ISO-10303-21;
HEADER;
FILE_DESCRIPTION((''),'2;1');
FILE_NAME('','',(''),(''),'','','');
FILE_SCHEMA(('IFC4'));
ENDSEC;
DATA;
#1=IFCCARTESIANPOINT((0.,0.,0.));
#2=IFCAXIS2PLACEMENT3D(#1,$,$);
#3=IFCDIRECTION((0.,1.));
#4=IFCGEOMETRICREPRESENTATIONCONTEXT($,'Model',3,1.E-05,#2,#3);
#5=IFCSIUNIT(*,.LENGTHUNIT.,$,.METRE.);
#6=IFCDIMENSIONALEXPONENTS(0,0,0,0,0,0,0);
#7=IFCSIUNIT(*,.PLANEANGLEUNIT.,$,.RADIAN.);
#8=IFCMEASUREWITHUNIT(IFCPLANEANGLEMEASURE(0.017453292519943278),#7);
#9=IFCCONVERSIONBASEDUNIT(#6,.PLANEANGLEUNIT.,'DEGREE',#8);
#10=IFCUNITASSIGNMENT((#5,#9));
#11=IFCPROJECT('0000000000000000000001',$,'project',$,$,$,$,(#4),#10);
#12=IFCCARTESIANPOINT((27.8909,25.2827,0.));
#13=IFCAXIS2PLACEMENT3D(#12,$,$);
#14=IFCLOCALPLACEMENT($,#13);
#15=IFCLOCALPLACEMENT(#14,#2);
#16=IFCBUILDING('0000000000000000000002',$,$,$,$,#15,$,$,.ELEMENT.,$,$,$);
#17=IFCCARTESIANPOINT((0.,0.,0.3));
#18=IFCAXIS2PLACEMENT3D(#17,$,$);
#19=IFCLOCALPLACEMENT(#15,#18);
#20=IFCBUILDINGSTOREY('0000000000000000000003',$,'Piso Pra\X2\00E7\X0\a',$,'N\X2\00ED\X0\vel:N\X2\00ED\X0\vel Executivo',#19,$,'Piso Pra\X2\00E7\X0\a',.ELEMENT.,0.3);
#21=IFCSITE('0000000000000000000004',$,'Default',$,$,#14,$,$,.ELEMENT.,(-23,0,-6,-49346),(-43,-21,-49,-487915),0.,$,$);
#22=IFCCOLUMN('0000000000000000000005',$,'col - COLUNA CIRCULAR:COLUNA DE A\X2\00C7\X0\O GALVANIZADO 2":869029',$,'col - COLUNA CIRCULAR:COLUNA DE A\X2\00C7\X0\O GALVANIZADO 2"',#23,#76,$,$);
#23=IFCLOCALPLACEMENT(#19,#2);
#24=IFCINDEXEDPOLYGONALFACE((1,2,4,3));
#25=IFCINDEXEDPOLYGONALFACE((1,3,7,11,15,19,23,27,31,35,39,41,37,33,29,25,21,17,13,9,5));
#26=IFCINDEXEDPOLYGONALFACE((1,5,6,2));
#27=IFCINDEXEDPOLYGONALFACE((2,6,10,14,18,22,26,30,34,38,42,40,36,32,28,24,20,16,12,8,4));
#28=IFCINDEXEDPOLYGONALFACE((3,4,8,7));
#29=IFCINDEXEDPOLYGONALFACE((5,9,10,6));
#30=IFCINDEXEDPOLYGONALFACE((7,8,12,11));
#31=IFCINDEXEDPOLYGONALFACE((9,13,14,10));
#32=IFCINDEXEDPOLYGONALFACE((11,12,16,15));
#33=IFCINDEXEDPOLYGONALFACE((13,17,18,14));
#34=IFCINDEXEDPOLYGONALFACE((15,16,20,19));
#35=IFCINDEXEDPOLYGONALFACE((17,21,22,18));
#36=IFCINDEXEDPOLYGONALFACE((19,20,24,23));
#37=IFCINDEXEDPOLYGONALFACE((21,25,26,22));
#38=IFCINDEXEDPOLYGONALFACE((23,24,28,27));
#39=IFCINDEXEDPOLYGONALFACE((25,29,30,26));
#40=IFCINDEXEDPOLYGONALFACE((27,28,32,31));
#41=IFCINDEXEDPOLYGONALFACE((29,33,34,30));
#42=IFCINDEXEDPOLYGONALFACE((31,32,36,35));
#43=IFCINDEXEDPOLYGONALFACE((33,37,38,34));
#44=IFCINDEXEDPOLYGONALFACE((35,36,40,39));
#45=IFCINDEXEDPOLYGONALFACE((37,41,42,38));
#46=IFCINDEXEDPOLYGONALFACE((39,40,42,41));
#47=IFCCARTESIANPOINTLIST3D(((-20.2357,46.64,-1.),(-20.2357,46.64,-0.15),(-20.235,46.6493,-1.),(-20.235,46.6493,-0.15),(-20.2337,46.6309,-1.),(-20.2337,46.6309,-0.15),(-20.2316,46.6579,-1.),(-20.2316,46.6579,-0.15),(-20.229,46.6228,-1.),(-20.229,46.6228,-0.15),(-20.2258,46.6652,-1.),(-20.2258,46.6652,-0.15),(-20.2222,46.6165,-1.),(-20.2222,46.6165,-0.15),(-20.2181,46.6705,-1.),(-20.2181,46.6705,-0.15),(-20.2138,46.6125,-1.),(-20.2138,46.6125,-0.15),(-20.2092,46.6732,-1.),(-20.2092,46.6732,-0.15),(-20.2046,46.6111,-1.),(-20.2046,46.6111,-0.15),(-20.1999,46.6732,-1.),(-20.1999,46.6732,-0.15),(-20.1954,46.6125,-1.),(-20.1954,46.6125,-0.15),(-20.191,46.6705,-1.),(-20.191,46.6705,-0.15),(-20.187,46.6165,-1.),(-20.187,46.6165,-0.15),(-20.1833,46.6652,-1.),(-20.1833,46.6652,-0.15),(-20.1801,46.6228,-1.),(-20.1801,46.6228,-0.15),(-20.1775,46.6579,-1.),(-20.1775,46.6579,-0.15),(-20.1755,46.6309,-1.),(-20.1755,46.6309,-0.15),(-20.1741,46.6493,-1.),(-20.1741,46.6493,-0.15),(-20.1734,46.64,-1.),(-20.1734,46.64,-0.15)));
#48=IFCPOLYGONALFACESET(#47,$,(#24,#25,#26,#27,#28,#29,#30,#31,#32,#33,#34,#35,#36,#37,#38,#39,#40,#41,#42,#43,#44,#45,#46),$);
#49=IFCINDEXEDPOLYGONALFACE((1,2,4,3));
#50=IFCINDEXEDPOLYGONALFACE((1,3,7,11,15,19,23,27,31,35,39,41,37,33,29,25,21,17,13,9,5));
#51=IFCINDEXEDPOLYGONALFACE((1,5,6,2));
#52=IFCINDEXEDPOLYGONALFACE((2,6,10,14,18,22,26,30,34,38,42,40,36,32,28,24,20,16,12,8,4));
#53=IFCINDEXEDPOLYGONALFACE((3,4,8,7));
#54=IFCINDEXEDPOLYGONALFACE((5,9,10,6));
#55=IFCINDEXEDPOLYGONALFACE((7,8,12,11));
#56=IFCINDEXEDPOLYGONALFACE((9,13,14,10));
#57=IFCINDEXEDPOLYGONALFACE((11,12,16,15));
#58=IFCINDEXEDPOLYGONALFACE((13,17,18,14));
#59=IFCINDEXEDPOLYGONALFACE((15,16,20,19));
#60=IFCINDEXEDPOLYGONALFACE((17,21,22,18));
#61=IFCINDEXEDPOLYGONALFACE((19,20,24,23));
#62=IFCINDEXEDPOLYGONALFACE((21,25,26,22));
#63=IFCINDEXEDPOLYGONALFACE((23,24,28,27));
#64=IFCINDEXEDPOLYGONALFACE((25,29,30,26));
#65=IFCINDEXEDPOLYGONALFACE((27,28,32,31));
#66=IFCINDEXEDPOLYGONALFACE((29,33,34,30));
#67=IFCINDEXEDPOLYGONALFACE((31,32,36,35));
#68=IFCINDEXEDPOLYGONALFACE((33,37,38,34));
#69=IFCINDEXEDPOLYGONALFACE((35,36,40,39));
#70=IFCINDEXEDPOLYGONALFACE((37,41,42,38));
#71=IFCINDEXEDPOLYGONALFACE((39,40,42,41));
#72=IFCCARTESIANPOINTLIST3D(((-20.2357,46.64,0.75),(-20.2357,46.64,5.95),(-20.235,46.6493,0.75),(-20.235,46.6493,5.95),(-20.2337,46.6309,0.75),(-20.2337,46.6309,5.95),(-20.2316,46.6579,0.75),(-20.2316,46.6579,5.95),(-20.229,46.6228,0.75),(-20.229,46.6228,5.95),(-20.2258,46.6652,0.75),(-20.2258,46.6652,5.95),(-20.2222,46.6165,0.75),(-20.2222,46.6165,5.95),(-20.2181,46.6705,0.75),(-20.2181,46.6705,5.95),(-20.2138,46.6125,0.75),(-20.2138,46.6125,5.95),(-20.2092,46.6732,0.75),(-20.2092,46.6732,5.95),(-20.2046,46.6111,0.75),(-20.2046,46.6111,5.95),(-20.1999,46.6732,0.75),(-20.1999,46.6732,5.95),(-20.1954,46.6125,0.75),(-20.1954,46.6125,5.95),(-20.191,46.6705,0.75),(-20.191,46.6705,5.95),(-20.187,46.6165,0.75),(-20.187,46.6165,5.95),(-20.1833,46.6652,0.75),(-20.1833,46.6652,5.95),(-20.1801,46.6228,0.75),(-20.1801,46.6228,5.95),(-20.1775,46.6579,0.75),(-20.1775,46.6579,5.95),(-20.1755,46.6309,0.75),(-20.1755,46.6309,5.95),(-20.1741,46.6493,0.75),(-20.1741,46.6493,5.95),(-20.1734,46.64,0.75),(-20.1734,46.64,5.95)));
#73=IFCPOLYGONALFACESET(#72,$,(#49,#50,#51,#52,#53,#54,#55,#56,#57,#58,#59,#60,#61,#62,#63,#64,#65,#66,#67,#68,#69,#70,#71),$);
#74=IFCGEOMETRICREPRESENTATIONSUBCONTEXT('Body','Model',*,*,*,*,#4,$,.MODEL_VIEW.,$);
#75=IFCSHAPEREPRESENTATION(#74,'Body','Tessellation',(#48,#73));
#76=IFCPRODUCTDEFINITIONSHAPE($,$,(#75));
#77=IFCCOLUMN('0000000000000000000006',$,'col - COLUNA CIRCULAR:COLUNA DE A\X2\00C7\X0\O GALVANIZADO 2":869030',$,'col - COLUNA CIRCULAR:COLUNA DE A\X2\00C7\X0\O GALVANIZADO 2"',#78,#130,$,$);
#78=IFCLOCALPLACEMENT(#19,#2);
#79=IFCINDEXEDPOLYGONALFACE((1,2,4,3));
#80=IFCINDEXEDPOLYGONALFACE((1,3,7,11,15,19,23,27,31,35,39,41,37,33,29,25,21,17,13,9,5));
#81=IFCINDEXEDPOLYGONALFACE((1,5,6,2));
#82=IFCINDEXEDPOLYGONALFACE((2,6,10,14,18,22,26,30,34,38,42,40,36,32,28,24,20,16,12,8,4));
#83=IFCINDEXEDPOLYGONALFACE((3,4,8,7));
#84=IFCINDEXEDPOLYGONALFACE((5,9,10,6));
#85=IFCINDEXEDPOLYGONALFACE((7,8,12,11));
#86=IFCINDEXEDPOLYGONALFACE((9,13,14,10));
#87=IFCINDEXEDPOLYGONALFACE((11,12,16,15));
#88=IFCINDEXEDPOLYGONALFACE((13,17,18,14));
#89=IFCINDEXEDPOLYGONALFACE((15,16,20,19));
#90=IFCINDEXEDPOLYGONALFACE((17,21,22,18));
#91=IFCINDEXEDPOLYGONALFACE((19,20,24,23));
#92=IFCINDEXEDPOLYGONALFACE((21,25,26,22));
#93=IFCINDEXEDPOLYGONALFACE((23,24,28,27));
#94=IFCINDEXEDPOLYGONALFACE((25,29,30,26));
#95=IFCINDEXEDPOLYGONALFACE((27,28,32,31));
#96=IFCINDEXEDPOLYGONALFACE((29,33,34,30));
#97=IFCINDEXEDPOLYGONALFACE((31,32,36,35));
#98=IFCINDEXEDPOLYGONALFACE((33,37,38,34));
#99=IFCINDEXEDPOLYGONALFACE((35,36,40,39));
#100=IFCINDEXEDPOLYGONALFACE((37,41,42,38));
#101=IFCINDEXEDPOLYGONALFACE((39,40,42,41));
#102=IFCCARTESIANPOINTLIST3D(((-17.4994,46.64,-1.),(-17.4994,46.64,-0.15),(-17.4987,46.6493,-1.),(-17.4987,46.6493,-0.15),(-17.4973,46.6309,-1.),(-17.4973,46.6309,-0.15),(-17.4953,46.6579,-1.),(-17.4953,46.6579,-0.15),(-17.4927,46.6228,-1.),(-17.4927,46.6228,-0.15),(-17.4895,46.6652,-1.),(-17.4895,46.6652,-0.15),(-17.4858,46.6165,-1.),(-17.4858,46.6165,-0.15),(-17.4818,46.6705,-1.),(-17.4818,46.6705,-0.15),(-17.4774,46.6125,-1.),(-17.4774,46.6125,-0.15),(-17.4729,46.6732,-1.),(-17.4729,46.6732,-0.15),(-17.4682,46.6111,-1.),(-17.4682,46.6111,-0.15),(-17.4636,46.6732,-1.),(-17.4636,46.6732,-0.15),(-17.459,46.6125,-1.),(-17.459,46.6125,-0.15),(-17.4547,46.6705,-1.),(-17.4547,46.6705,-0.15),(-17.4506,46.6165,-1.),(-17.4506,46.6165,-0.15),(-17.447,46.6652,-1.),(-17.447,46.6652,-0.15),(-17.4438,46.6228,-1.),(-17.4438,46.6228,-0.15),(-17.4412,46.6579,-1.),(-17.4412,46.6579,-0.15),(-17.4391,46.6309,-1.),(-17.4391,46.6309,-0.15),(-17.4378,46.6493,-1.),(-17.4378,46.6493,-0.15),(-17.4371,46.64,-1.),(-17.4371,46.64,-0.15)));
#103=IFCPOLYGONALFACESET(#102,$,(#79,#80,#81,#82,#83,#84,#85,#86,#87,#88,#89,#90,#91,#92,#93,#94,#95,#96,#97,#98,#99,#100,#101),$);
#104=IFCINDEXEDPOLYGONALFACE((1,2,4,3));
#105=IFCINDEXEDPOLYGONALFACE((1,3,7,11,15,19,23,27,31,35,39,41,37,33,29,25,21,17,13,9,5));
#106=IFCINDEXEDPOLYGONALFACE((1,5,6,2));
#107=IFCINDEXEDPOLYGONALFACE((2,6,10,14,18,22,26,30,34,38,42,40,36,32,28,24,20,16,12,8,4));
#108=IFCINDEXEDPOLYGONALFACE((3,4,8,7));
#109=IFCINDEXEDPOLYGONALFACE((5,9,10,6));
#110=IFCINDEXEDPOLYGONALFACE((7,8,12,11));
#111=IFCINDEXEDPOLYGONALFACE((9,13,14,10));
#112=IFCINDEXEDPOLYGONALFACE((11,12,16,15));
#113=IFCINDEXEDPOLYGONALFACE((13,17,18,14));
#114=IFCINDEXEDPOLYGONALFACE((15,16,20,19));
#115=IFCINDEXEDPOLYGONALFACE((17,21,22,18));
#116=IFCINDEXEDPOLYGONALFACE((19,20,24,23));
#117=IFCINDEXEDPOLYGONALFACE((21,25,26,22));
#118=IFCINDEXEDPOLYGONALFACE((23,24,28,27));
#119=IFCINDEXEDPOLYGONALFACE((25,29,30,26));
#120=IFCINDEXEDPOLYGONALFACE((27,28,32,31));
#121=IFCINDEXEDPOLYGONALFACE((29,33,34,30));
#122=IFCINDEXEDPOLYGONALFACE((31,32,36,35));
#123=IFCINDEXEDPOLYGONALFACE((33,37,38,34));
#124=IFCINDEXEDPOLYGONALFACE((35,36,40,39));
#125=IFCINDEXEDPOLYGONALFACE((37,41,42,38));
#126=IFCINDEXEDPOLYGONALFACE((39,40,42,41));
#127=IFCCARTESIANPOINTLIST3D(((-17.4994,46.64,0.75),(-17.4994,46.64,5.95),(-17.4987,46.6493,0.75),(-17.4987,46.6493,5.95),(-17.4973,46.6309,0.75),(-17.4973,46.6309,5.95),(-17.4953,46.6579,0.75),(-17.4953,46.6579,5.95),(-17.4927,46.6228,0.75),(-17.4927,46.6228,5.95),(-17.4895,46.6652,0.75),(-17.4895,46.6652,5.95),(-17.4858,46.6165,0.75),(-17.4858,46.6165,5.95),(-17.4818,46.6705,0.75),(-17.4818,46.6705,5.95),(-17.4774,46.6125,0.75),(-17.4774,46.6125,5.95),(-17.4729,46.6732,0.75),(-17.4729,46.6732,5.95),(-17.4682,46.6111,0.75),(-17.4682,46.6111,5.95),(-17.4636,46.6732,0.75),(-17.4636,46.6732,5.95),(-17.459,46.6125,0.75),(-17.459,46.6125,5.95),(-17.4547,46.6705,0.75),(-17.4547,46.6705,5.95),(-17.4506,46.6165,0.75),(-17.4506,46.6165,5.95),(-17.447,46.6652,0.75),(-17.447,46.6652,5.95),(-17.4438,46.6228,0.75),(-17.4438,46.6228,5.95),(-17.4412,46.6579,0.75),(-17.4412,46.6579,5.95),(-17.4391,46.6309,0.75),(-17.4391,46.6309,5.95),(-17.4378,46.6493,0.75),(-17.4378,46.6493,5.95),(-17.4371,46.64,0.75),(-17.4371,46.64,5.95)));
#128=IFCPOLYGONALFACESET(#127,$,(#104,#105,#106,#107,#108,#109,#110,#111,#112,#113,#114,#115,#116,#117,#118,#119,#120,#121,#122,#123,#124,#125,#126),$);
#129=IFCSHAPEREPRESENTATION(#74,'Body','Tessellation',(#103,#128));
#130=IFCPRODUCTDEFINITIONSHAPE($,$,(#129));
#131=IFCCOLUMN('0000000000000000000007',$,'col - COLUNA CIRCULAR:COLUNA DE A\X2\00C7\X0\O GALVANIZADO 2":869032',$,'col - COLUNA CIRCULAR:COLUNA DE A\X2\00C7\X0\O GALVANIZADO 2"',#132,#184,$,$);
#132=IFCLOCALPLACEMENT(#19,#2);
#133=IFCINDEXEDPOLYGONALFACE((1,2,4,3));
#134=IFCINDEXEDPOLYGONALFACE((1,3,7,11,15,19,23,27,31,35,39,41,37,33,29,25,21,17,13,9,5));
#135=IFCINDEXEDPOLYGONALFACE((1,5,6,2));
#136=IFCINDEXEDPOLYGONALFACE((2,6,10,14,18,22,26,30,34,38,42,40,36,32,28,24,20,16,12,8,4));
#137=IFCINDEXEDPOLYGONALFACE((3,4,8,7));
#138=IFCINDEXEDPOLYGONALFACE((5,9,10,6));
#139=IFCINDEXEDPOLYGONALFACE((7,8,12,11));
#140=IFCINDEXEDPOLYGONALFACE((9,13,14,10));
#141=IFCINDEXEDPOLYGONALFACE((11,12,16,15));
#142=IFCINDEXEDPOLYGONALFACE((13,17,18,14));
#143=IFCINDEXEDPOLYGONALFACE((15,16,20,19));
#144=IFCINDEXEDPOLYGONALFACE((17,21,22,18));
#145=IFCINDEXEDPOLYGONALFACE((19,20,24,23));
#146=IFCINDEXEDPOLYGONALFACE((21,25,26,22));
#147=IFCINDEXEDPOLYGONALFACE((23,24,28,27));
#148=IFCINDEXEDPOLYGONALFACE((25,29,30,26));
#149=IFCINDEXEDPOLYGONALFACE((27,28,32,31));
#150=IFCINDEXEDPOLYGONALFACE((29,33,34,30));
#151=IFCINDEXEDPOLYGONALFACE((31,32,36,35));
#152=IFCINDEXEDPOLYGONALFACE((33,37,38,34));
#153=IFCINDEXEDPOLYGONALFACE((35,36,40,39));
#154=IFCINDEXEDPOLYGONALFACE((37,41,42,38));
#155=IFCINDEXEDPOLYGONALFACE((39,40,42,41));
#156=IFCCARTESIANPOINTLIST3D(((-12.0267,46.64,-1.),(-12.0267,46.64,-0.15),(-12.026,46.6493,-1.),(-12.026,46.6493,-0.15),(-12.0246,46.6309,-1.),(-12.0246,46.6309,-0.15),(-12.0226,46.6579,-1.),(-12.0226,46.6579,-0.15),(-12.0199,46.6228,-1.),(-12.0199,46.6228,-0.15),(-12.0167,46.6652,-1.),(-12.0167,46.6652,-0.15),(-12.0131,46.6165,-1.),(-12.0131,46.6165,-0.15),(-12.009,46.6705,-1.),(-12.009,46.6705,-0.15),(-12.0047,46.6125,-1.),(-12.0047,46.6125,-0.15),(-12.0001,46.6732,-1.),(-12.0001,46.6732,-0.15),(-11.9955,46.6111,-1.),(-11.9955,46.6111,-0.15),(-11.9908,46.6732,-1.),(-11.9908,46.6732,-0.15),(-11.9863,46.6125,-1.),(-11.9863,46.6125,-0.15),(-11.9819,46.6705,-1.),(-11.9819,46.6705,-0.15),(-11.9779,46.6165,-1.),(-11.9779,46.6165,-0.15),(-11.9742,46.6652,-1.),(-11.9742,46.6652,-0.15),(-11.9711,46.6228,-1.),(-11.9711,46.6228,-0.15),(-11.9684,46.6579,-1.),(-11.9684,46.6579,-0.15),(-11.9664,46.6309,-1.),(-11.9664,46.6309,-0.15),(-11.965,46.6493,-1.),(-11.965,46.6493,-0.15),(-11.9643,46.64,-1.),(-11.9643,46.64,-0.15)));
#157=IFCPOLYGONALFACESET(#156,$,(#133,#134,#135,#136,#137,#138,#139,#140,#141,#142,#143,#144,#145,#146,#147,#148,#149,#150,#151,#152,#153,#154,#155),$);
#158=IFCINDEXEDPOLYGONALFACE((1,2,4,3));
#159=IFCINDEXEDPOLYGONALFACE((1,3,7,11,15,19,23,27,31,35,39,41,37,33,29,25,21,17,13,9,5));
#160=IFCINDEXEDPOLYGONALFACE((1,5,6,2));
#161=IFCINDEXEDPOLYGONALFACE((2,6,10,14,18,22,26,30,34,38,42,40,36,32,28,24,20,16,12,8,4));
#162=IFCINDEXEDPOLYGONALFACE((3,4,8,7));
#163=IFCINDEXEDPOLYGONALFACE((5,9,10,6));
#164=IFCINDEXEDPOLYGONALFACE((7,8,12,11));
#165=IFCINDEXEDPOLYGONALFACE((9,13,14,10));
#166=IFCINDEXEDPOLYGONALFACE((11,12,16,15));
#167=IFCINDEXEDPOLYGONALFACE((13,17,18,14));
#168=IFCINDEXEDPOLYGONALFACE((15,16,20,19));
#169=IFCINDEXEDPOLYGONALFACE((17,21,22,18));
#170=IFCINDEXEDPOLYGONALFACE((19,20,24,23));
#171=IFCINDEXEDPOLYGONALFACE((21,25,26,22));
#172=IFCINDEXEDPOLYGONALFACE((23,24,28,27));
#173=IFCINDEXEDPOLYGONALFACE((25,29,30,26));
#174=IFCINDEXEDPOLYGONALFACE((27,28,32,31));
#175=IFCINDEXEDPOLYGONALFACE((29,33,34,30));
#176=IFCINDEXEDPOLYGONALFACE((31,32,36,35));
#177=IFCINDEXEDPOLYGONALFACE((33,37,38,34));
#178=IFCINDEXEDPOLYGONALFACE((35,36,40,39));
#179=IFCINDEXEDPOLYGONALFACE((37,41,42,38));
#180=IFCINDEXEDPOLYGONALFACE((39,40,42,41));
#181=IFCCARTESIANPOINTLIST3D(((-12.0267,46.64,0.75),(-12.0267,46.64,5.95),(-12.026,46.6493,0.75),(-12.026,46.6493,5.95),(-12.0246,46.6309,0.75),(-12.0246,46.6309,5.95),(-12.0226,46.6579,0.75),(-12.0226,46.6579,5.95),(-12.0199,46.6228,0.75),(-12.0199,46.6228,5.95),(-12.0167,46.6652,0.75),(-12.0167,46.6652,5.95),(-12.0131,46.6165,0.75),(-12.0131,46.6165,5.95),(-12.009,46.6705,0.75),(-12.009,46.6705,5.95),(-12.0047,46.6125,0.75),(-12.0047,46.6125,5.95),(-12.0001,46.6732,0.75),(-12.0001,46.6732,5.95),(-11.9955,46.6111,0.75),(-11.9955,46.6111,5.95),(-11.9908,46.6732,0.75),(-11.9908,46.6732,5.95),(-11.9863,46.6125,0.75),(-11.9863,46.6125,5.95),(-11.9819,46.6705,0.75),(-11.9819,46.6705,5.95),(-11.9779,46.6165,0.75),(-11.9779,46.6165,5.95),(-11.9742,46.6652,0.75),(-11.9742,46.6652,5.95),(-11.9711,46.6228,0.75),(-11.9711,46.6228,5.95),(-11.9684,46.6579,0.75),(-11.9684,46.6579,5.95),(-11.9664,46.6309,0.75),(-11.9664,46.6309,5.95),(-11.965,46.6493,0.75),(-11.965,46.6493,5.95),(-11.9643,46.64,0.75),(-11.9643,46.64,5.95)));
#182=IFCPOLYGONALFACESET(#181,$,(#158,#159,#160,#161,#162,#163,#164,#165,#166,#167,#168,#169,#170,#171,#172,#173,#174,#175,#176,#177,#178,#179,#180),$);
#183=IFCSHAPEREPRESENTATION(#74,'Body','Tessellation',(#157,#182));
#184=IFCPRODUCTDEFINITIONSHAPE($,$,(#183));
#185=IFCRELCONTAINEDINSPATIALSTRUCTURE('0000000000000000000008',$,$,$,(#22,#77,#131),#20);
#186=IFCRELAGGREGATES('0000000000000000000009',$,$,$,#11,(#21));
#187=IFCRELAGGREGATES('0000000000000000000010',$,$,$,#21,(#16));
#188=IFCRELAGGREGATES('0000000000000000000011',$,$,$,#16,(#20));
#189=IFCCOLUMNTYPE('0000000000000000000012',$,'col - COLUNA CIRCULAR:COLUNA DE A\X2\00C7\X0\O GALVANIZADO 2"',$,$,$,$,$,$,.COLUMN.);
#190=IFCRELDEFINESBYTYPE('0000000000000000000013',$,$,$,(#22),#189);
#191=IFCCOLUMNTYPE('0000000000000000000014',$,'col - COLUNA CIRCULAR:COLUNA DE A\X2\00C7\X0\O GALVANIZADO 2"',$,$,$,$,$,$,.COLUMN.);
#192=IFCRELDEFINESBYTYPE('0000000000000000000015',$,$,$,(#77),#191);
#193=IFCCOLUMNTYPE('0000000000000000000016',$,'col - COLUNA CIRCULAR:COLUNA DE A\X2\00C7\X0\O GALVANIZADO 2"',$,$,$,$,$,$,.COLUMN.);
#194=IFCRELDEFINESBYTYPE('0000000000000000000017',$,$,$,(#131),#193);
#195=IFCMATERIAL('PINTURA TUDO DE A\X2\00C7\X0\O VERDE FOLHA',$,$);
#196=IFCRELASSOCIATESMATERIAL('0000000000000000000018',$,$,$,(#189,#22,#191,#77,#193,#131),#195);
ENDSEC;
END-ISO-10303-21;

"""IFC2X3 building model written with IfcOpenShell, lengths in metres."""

from ifc_helpers import new_model, entity, si_unit, converted_unit, direction, frame, origin, origin_2d_with_axis, place, context, subcontext, project, spatial, circle, extrude, source, transform, mapped, material, type_object, type_shapes, element, save


model = new_model("IFC2X3")

# Units and contexts
model_context = context("Model", 3, precision=1e-05, world=origin(), true_north=direction((0.0, 1.0)))
body_context = subcontext(model_context, "Body", "Model", "MODEL_VIEW")
ifc_project = project(units=[si_unit("LENGTHUNIT", "METRE"), converted_unit("PLANEANGLEUNIT", "DEGREE", entity("IfcPlaneAngleMeasure", 0.017453292519943278), si_unit("PLANEANGLEUNIT", "RADIAN"), dimensions=[0, 0, 0, 0, 0, 0, 0])], contexts=[model_context])

# Site, building, storey
site_placement = place(None, frame((27.8909, 25.2827, 0.0)))
site = spatial("IfcSite", under=ifc_project, at=site_placement, Name="Default", CompositionType="ELEMENT", RefLatitude=(-23, 0, -6, -49346), RefLongitude=(-43, -21, -49, -487915), RefElevation=0.0)
building_placement = place(site_placement, origin())
building = spatial("IfcBuilding", under=site, at=building_placement, CompositionType="ELEMENT")
storey_placement = place(building_placement, frame((0.0, 0.0, 0.3)))
storey = spatial("IfcBuildingStorey", under=building, at=storey_placement, Name="Piso Praça", ObjectType="Nível:Nível Executivo", LongName="Piso Praça", CompositionType="ELEMENT", Elevation=0.3)

# Columns
ifc_material = material(Name="PINTURA TUDO DE AÇO VERDE FOLHA")
column_type_1 = type_object("IfcColumnType", Name="col - COLUNA CIRCULAR:COLUNA DE AÇO GALVANIZADO 2\"", PredefinedType="COLUMN", material=ifc_material)
shared_shape_1 = source(origin(), body_context, "Body", "SweptSolid", [
    extrude(circle(Radius=0.0312, at=origin_2d_with_axis()), frame((-20.2046, 46.6423, -0.7), z_axis=(0.0, 0.0, 1.0), x_axis=(0.0, -1.0, 0.0)), (0.0, 0.0, 1.0), 0.85),
    extrude(circle(Radius=0.0312, at=origin_2d_with_axis()), frame((-20.2046, 46.6423, 1.05), z_axis=(0.0, 0.0, 1.0), x_axis=(0.0, -1.0, 0.0)), (0.0, 0.0, 1.0), 5.2),
])
type_shapes(column_type_1, [shared_shape_1])
column_1_placement = place(storey_placement, frame((0.0, 0.0, -0.3)))
element("IfcColumn", 1, at=column_1_placement, inside=storey, type_object=column_type_1, material=ifc_material, Name="col - COLUNA CIRCULAR:COLUNA DE AÇO GALVANIZADO 2\":869029", ObjectType="col - COLUNA CIRCULAR:COLUNA DE AÇO GALVANIZADO 2\"", context=body_context, shape_type="MappedRepresentation", body=[
    mapped(shared_shape_1, transform((0.0, 0.0, 0.0), scale=1.0)),
])
column_type_2 = type_object("IfcColumnType", Name="col - COLUNA CIRCULAR:COLUNA DE AÇO GALVANIZADO 2\"", PredefinedType="COLUMN", material=ifc_material)
shared_shape_2 = source(origin(), body_context, "Body", "SweptSolid", [
    extrude(circle(Radius=0.0312, at=origin_2d_with_axis()), frame((-17.4682, 46.6423, -0.7), z_axis=(0.0, 0.0, 1.0), x_axis=(0.0, -1.0, 0.0)), (0.0, 0.0, 1.0), 0.85),
    extrude(circle(Radius=0.0312, at=origin_2d_with_axis()), frame((-17.4682, 46.6423, 1.05), z_axis=(0.0, 0.0, 1.0), x_axis=(0.0, -1.0, 0.0)), (0.0, 0.0, 1.0), 5.2),
])
type_shapes(column_type_2, [shared_shape_2])
column_2_placement = place(storey_placement, frame((0.0, 0.0, -0.3)))
element("IfcColumn", 2, at=column_2_placement, inside=storey, type_object=column_type_2, material=ifc_material, Name="col - COLUNA CIRCULAR:COLUNA DE AÇO GALVANIZADO 2\":869030", ObjectType="col - COLUNA CIRCULAR:COLUNA DE AÇO GALVANIZADO 2\"", context=body_context, shape_type="MappedRepresentation", body=[
    mapped(shared_shape_2, transform((0.0, 0.0, 0.0), scale=1.0)),
])
column_type_3 = type_object("IfcColumnType", Name="col - COLUNA CIRCULAR:COLUNA DE AÇO GALVANIZADO 2\"", PredefinedType="COLUMN", material=ifc_material)
shared_shape_3 = source(origin(), body_context, "Body", "SweptSolid", [
    extrude(circle(Radius=0.0312, at=origin_2d_with_axis()), frame((-11.9955, 46.6423, -0.7), z_axis=(0.0, 0.0, 1.0), x_axis=(0.0, -1.0, 0.0)), (0.0, 0.0, 1.0), 0.85),
    extrude(circle(Radius=0.0312, at=origin_2d_with_axis()), frame((-11.9955, 46.6423, 1.05), z_axis=(0.0, 0.0, 1.0), x_axis=(0.0, -1.0, 0.0)), (0.0, 0.0, 1.0), 5.2),
])
type_shapes(column_type_3, [shared_shape_3])
column_3_placement = place(storey_placement, frame((0.0, 0.0, -0.3)))
element("IfcColumn", 3, at=column_3_placement, inside=storey, type_object=column_type_3, material=ifc_material, Name="col - COLUNA CIRCULAR:COLUNA DE AÇO GALVANIZADO 2\":869032", ObjectType="col - COLUNA CIRCULAR:COLUNA DE AÇO GALVANIZADO 2\"", context=body_context, shape_type="MappedRepresentation", body=[
    mapped(shared_shape_3, transform((0.0, 0.0, 0.0), scale=1.0)),
])

save(model, "model.ifc")
